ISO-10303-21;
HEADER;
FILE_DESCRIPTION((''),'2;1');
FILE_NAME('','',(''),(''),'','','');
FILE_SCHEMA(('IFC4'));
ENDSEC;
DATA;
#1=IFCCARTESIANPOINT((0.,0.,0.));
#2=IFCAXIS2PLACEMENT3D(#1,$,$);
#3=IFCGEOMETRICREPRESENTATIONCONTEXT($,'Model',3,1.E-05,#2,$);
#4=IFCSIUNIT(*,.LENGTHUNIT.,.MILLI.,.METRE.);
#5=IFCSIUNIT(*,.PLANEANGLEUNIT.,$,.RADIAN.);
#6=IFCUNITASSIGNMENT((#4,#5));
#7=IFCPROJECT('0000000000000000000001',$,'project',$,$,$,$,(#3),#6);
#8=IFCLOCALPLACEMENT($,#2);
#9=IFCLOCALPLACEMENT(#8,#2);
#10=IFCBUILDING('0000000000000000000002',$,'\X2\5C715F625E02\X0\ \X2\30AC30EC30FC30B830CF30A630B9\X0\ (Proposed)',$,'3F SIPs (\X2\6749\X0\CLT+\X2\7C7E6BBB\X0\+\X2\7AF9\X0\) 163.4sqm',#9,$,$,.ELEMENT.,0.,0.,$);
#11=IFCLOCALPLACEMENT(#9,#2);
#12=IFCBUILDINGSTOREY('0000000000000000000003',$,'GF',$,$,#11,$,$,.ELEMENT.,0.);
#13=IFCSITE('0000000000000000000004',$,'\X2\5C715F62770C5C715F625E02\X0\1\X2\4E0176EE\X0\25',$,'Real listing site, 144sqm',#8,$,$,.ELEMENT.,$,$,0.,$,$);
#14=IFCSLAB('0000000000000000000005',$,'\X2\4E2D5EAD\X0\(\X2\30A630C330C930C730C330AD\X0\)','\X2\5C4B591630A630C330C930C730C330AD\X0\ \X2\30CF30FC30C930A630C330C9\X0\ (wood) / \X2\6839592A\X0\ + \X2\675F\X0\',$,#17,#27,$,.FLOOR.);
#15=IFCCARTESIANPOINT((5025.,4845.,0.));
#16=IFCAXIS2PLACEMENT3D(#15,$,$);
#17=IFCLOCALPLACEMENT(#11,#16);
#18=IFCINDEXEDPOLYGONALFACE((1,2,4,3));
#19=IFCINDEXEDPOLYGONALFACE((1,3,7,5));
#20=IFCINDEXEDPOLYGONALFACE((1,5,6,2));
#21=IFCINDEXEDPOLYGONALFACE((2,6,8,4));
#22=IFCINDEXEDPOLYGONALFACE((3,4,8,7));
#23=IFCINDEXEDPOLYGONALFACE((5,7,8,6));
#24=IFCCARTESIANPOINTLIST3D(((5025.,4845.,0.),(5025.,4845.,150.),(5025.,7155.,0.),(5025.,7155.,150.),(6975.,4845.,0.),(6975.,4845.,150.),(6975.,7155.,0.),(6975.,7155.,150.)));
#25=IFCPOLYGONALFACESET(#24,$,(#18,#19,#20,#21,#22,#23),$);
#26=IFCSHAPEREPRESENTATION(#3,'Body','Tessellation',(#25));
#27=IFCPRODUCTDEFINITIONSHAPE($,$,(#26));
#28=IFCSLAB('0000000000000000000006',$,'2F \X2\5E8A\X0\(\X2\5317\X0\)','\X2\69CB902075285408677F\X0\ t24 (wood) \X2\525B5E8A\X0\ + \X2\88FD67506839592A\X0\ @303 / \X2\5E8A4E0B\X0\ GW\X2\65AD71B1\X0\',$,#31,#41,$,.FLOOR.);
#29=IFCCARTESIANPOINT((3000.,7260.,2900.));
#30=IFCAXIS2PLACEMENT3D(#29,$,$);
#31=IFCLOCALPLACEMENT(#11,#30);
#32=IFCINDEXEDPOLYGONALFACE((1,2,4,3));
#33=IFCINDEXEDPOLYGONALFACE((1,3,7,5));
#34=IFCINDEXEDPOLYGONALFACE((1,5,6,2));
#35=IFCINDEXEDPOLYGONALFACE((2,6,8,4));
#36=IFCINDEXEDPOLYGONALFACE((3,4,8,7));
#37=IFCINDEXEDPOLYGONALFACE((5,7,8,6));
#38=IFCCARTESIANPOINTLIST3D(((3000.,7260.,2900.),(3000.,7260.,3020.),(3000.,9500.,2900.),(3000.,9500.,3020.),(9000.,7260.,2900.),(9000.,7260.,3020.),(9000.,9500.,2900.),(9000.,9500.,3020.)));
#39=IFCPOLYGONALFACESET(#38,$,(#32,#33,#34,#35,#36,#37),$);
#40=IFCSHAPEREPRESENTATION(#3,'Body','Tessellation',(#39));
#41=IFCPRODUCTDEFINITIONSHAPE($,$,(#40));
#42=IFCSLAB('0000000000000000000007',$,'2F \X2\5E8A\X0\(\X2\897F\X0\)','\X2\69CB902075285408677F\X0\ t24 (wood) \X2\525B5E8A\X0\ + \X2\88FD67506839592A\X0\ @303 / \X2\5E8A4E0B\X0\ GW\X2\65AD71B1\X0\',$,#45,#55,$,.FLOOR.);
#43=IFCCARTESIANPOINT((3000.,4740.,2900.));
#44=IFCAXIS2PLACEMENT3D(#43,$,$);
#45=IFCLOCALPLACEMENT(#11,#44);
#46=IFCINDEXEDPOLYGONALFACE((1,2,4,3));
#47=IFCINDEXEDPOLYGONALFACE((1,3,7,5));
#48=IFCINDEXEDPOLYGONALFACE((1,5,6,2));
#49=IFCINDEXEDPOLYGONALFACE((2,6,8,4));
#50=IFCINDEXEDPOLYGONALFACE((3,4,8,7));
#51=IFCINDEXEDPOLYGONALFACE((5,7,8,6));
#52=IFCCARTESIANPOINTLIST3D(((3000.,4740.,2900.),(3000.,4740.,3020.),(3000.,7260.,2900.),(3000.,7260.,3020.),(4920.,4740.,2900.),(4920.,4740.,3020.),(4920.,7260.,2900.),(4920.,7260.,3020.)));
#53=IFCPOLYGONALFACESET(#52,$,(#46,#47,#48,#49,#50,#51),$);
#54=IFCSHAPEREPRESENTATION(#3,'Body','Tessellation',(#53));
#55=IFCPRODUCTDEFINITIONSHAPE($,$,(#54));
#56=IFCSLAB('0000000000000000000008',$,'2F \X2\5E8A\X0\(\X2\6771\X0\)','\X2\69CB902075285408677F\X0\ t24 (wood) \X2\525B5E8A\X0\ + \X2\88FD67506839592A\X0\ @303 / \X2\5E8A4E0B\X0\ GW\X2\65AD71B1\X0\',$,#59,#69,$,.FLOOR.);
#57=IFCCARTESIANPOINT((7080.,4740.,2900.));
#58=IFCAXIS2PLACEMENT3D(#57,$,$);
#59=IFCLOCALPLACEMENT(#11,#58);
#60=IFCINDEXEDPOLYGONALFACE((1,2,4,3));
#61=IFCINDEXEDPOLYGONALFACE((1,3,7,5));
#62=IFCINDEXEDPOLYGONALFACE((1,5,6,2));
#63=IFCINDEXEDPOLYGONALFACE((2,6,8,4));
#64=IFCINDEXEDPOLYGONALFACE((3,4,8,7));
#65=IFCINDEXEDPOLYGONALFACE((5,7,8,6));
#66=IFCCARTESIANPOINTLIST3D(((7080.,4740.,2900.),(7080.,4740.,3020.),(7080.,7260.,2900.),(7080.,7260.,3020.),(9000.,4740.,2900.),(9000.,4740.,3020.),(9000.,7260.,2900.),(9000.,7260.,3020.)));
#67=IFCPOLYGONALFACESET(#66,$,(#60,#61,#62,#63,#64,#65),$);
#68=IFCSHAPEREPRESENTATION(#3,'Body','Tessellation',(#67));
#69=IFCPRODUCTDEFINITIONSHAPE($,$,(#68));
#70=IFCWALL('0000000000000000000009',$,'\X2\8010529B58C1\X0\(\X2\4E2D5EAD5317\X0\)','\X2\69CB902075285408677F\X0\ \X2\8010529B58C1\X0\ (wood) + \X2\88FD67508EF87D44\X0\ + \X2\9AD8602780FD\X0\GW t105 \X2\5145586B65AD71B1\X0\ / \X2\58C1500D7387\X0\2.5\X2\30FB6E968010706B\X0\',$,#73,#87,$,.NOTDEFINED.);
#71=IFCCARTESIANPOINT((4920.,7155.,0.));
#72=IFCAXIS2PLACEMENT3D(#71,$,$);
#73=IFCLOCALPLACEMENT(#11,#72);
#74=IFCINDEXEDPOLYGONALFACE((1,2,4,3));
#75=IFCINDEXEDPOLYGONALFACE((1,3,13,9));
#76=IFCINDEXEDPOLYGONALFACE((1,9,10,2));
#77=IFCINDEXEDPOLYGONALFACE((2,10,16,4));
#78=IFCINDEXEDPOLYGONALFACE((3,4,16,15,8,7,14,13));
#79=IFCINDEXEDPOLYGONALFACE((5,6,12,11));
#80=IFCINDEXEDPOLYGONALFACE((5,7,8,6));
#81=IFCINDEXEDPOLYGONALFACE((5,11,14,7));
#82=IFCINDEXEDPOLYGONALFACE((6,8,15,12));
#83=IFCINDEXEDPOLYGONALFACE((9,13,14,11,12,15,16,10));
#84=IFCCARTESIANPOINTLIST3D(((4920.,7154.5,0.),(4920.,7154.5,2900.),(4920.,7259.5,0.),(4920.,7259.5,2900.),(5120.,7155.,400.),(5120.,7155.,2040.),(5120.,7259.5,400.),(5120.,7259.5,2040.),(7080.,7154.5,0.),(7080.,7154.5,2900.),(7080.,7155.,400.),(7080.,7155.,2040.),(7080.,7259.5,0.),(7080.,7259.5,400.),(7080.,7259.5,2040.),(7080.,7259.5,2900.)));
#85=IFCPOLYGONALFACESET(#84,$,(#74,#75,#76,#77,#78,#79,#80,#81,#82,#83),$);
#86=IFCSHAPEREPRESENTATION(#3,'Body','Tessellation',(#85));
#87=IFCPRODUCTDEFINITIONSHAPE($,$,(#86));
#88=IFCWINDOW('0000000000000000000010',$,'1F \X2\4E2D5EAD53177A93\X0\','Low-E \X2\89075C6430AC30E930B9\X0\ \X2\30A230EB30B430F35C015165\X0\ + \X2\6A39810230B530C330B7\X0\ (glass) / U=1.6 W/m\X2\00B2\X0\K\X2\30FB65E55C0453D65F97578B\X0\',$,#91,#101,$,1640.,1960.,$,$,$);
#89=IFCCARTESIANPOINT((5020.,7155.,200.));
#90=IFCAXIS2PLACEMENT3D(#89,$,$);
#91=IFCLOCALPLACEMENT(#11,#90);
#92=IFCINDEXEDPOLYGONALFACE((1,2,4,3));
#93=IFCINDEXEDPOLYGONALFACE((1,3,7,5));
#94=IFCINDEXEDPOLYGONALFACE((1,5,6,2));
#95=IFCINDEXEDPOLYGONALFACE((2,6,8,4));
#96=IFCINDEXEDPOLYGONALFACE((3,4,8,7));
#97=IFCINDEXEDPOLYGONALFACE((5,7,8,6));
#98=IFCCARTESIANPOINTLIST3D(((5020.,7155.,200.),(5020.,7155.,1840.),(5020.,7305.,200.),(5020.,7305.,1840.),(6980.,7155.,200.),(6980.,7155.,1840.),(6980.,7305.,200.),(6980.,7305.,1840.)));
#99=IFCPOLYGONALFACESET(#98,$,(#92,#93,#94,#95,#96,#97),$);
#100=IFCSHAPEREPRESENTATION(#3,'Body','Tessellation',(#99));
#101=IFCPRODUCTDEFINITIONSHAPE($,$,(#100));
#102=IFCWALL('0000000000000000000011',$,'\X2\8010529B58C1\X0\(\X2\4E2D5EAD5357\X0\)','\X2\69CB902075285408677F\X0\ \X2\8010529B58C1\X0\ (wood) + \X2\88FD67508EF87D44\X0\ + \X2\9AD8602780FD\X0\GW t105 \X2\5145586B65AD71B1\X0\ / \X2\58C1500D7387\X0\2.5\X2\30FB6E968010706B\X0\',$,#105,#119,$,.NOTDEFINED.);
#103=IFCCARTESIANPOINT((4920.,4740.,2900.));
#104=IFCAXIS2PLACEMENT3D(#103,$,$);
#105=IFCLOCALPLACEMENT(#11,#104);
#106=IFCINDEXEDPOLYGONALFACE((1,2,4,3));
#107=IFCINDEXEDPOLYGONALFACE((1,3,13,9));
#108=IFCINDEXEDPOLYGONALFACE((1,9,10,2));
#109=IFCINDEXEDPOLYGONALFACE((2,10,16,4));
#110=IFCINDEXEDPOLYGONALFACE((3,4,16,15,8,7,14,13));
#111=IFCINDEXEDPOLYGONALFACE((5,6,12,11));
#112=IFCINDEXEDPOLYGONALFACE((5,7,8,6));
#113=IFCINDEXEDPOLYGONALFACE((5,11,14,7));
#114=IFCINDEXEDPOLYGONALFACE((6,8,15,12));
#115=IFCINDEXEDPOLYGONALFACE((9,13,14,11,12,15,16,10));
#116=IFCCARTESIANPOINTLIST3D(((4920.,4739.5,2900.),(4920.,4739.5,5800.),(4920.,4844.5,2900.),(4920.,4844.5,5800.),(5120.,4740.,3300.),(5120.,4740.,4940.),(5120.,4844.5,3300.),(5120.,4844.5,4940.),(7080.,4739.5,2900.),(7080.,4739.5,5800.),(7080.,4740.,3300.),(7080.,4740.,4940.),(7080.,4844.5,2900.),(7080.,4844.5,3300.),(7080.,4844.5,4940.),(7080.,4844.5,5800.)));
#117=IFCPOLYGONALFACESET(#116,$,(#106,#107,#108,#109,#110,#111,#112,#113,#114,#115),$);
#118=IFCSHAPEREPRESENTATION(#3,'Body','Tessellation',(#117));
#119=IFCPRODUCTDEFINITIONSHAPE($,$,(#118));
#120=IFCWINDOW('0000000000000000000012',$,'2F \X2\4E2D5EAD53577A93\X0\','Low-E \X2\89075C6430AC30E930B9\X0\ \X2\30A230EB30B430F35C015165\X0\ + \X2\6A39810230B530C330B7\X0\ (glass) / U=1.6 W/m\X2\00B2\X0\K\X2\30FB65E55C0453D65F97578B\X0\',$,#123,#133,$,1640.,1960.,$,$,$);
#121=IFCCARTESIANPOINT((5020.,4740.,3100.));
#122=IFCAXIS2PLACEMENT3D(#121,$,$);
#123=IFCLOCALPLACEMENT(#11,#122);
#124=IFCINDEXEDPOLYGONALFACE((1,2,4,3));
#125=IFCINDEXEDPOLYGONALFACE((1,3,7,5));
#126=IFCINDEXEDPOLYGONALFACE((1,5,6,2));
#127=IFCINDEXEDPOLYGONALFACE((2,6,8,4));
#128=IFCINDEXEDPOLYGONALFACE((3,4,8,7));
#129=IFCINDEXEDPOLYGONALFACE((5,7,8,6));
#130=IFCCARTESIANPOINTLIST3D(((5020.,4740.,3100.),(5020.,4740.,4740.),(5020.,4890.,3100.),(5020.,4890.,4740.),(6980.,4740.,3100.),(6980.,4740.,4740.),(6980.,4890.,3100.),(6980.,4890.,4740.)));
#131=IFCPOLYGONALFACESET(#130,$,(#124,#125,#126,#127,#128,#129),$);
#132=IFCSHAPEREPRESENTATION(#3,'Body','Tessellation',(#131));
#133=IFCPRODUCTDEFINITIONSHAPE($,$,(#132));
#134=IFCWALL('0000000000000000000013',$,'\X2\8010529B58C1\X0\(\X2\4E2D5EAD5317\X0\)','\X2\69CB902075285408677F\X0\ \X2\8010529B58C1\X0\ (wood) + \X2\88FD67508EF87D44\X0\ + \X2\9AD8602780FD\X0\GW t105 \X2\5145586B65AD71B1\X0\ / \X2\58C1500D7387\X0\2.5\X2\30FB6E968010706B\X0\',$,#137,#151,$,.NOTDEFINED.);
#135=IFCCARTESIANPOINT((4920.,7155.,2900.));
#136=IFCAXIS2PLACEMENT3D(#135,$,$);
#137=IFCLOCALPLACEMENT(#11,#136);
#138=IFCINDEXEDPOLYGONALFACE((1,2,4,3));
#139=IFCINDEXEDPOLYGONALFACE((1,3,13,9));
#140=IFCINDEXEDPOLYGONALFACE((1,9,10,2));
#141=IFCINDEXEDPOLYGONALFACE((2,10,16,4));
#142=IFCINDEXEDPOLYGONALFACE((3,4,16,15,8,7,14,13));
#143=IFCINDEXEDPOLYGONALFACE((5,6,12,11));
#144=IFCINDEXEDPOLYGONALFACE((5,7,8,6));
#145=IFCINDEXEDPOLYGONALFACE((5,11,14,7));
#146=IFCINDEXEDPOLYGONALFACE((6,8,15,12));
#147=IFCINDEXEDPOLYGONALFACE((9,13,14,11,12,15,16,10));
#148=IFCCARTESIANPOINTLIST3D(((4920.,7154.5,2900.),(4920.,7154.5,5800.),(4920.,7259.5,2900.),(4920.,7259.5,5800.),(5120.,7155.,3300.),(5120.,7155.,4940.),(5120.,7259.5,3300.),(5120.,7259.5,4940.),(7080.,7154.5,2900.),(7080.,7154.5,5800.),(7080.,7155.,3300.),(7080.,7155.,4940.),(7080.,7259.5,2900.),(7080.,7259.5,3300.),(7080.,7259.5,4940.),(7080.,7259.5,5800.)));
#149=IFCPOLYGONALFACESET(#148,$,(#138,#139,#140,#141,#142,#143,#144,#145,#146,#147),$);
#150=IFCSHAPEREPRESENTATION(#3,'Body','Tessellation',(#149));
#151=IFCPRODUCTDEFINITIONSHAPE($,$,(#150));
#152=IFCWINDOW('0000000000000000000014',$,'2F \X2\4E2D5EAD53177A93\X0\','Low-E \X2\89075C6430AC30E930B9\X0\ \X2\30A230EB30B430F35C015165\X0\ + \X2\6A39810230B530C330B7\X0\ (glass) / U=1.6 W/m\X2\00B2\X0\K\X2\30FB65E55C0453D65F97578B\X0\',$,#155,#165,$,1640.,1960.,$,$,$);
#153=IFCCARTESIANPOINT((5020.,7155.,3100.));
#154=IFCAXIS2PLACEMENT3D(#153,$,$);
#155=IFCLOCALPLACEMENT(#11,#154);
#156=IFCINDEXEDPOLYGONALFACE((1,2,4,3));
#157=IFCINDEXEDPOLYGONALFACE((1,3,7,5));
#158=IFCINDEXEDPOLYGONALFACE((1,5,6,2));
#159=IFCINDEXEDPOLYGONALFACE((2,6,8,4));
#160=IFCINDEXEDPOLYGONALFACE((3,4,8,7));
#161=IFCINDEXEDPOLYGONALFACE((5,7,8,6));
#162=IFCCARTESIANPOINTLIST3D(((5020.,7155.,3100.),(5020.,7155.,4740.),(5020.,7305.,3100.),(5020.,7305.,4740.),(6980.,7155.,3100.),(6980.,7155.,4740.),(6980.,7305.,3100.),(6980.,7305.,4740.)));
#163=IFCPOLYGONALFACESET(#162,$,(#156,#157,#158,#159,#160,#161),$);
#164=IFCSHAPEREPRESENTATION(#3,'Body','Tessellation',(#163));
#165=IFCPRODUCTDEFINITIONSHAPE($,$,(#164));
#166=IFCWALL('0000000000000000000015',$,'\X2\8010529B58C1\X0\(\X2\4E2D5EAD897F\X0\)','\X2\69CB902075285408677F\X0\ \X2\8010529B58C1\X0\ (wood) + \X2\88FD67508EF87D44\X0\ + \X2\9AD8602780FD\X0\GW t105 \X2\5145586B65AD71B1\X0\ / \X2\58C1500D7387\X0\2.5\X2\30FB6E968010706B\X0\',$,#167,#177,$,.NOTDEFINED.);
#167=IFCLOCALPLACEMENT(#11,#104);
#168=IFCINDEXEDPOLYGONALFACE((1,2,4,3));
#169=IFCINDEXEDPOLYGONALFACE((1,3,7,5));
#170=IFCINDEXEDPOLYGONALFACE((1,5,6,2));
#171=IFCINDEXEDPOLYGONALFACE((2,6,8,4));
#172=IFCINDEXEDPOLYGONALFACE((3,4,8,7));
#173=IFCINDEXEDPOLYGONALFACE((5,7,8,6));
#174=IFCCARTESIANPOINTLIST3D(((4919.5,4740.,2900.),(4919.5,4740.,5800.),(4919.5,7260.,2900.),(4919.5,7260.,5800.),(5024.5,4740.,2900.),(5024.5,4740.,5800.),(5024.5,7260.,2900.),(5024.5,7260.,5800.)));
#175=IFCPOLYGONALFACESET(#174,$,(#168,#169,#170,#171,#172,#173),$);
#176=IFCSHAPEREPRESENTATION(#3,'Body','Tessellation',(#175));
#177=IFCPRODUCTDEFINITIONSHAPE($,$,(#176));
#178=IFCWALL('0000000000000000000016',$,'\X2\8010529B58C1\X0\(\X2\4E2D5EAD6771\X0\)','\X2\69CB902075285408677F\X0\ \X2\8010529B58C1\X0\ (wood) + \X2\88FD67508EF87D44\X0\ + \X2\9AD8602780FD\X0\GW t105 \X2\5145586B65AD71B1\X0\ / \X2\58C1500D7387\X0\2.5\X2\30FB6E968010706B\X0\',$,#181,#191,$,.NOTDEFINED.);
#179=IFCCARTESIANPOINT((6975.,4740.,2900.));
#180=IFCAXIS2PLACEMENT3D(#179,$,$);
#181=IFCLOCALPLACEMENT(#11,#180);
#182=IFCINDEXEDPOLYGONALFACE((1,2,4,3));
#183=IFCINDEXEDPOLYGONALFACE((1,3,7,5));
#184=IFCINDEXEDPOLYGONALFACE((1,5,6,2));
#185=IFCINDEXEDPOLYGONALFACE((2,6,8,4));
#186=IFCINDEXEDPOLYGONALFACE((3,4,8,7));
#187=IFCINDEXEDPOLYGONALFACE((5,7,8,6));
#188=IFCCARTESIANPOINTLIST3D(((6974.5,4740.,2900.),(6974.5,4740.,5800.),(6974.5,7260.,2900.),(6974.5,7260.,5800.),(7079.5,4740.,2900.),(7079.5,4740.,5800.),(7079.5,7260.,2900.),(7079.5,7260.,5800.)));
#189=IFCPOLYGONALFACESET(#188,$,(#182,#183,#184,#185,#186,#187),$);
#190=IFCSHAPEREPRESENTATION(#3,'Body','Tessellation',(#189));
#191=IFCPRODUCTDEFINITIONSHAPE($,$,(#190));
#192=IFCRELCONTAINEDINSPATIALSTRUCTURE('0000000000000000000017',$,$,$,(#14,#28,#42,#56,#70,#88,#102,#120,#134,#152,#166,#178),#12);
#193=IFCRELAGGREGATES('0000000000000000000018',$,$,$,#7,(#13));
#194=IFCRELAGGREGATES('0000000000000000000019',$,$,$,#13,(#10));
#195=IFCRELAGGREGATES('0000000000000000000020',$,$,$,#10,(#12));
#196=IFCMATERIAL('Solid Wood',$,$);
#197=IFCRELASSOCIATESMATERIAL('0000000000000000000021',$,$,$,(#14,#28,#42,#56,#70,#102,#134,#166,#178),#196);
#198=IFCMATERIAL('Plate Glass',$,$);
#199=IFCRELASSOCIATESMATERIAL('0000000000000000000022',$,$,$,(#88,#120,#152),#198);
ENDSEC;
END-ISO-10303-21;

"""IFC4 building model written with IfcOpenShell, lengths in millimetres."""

from ifc_helpers import new_model, si_unit, frame, frame_2d, origin, place, context, project, spatial, rectangle, extrude, material, element, fill, save


model = new_model("IFC4")

# Units and contexts
model_context = context("Model", 3, precision=1e-05, world=origin())
ifc_project = project(units=[si_unit("LENGTHUNIT", "METRE", prefix="MILLI"), si_unit("PLANEANGLEUNIT", "RADIAN")], contexts=[model_context])

# Site, building, storey
site_placement = place(None, origin())
site = spatial("IfcSite", under=ifc_project, at=site_placement, Name="山形県山形市1丁目25", ObjectType="Real listing site, 144sqm", CompositionType="ELEMENT", RefElevation=0.0)
building_placement = place(site_placement, origin())
building = spatial("IfcBuilding", under=site, at=building_placement, Name="山形市 ガレージハウス (Proposed)", ObjectType="3F SIPs (杉CLT+籾殻+竹) 163.4sqm", CompositionType="ELEMENT", ElevationOfRefHeight=0.0, ElevationOfTerrain=0.0)
storey_placement = place(building_placement, origin())
storey = spatial("IfcBuildingStorey", under=building, at=storey_placement, Name="GF", CompositionType="ELEMENT", Elevation=0.0)

# Slabs
ifc_material_1 = material(Name="Solid Wood")
slab_1_placement = place(storey_placement, frame((5025.0, 4845.0, 0.0)))
element("IfcSlab", 1, at=slab_1_placement, inside=storey, material=ifc_material_1, Name="中庭(ウッドデッキ)", Description="屋外ウッドデッキ ハードウッド (wood) / 根太 + 束", PredefinedType="FLOOR", context=model_context, shape_type="SweptSolid", body=[
    extrude(rectangle(XDim=1950.0, YDim=2310.0, at=frame_2d((975.0, 1155.0))), frame((5025.0, 4845.0, 0.0)), (0.0, 0.0, 1.0), 150.0),
])
slab_2_placement = place(storey_placement, frame((3000.0, 7260.0, 2900.0)))
element("IfcSlab", 2, at=slab_2_placement, inside=storey, material=ifc_material_1, Name="2F 床(北)", Description="構造用合板 t24 (wood) 剛床 + 製材根太 @303 / 床下 GW断熱", PredefinedType="FLOOR", context=model_context, shape_type="SweptSolid", body=[
    extrude(rectangle(XDim=6000.0, YDim=2240.0, at=frame_2d((3000.0, 1120.0))), frame((3000.0, 7260.0, 2900.0)), (0.0, 0.0, 1.0), 120.0),
])
slab_3_placement = place(storey_placement, frame((3000.0, 4740.0, 2900.0)))
element("IfcSlab", 3, at=slab_3_placement, inside=storey, material=ifc_material_1, Name="2F 床(西)", Description="構造用合板 t24 (wood) 剛床 + 製材根太 @303 / 床下 GW断熱", PredefinedType="FLOOR", context=model_context, shape_type="SweptSolid", body=[
    extrude(rectangle(XDim=1920.0, YDim=2520.0, at=frame_2d((960.0, 1260.0))), frame((3000.0, 4740.0, 2900.0)), (0.0, 0.0, 1.0), 120.0),
])
slab_4_placement = place(storey_placement, frame((7080.0, 4740.0, 2900.0)))
element("IfcSlab", 4, at=slab_4_placement, inside=storey, material=ifc_material_1, Name="2F 床(東)", Description="構造用合板 t24 (wood) 剛床 + 製材根太 @303 / 床下 GW断熱", PredefinedType="FLOOR", context=model_context, shape_type="SweptSolid", body=[
    extrude(rectangle(XDim=1920.0, YDim=2520.0, at=frame_2d((960.0, 1260.0))), frame((7080.0, 4740.0, 2900.0)), (0.0, 0.0, 1.0), 120.0),
])

# Wall, opening, window
wall_1_placement = place(storey_placement, frame((4920.0, 7155.0, 0.0)))
wall_1 = element("IfcWall", 5, at=wall_1_placement, inside=storey, material=ifc_material_1, Name="耐力壁(中庭北)", Description="構造用合板 耐力壁 (wood) + 製材軸組 + 高性能GW t105 充填断熱 / 壁倍率2.5・準耐火", PredefinedType="NOTDEFINED", context=model_context, shape_type="SweptSolid", body=[
    extrude(rectangle(XDim=2160.0, YDim=105.0, at=frame_2d((1080.0, 52.0))), frame((4920.0, 7155.0, 0.0)), (0.0, 0.0, 1.0), 2900.0),
])
opening_1_placement = place(storey_placement, frame((5020.0, 7155.0, 200.0)))
opening_1 = element("IfcOpeningElement", 6, at=opening_1_placement, cuts=wall_1, PredefinedType="NOTDEFINED", context=model_context, shape_type="SweptSolid", body=[
    extrude(rectangle(XDim=1960.0, YDim=150.0, at=frame_2d((980.0, 75.0))), frame((5020.0, 7155.0, 200.0)), (0.0, 0.0, 1.0), 1640.0),
])
ifc_material_2 = material(Name="Plate Glass")
window_1_placement = place(storey_placement, frame((5020.0, 7155.0, 200.0)))
window_1 = element("IfcWindow", 7, at=window_1_placement, inside=storey, material=ifc_material_2, Name="1F 中庭北窓", Description="Low-E 複層ガラス アルゴン封入 + 樹脂サッシ (glass) / U=1.6 W/m²K・日射取得型", OverallHeight=1640.0, OverallWidth=1960.0, context=model_context, shape_type="SweptSolid", body=[
    extrude(rectangle(XDim=1960.0, YDim=150.0, at=frame_2d((980.0, 75.0))), frame((5020.0, 7155.0, 200.0)), (0.0, 0.0, 1.0), 1640.0),
])
fill(opening_1, window_1)

# Walls, openings, windows
wall_2_placement = place(storey_placement, frame((4920.0, 4740.0, 2900.0)))
wall_2 = element("IfcWall", 8, at=wall_2_placement, inside=storey, material=ifc_material_1, Name="耐力壁(中庭南)", Description="構造用合板 耐力壁 (wood) + 製材軸組 + 高性能GW t105 充填断熱 / 壁倍率2.5・準耐火", PredefinedType="NOTDEFINED", context=model_context, shape_type="SweptSolid", body=[
    extrude(rectangle(XDim=2160.0, YDim=105.0, at=frame_2d((1080.0, 52.0))), frame((4920.0, 4740.0, 2900.0)), (0.0, 0.0, 1.0), 2900.0),
])
opening_2_placement = place(storey_placement, frame((5020.0, 4740.0, 3100.0)))
opening_2 = element("IfcOpeningElement", 9, at=opening_2_placement, cuts=wall_2, PredefinedType="NOTDEFINED", context=model_context, shape_type="SweptSolid", body=[
    extrude(rectangle(XDim=1960.0, YDim=150.0, at=frame_2d((980.0, 75.0))), frame((5020.0, 4740.0, 3100.0)), (0.0, 0.0, 1.0), 1640.0),
])
window_2_placement = place(storey_placement, frame((5020.0, 4740.0, 3100.0)))
window_2 = element("IfcWindow", 10, at=window_2_placement, inside=storey, material=ifc_material_2, Name="2F 中庭南窓", Description="Low-E 複層ガラス アルゴン封入 + 樹脂サッシ (glass) / U=1.6 W/m²K・日射取得型", OverallHeight=1640.0, OverallWidth=1960.0, context=model_context, shape_type="SweptSolid", body=[
    extrude(rectangle(XDim=1960.0, YDim=150.0, at=frame_2d((980.0, 75.0))), frame((5020.0, 4740.0, 3100.0)), (0.0, 0.0, 1.0), 1640.0),
])
fill(opening_2, window_2)
wall_3_placement = place(storey_placement, frame((4920.0, 7155.0, 2900.0)))
wall_3 = element("IfcWall", 11, at=wall_3_placement, inside=storey, material=ifc_material_1, Name="耐力壁(中庭北)", Description="構造用合板 耐力壁 (wood) + 製材軸組 + 高性能GW t105 充填断熱 / 壁倍率2.5・準耐火", PredefinedType="NOTDEFINED", context=model_context, shape_type="SweptSolid", body=[
    extrude(rectangle(XDim=2160.0, YDim=105.0, at=frame_2d((1080.0, 52.0))), frame((4920.0, 7155.0, 2900.0)), (0.0, 0.0, 1.0), 2900.0),
])
opening_3_placement = place(storey_placement, frame((5020.0, 7155.0, 3100.0)))
opening_3 = element("IfcOpeningElement", 12, at=opening_3_placement, cuts=wall_3, PredefinedType="NOTDEFINED", context=model_context, shape_type="SweptSolid", body=[
    extrude(rectangle(XDim=1960.0, YDim=150.0, at=frame_2d((980.0, 75.0))), frame((5020.0, 7155.0, 3100.0)), (0.0, 0.0, 1.0), 1640.0),
])
window_3_placement = place(storey_placement, frame((5020.0, 7155.0, 3100.0)))
window_3 = element("IfcWindow", 13, at=window_3_placement, inside=storey, material=ifc_material_2, Name="2F 中庭北窓", Description="Low-E 複層ガラス アルゴン封入 + 樹脂サッシ (glass) / U=1.6 W/m²K・日射取得型", OverallHeight=1640.0, OverallWidth=1960.0, context=model_context, shape_type="SweptSolid", body=[
    extrude(rectangle(XDim=1960.0, YDim=150.0, at=frame_2d((980.0, 75.0))), frame((5020.0, 7155.0, 3100.0)), (0.0, 0.0, 1.0), 1640.0),
])
fill(opening_3, window_3)

# Walls
wall_4_placement = place(storey_placement, frame((4920.0, 4740.0, 2900.0)))
element("IfcWall", 14, at=wall_4_placement, inside=storey, material=ifc_material_1, Name="耐力壁(中庭西)", Description="構造用合板 耐力壁 (wood) + 製材軸組 + 高性能GW t105 充填断熱 / 壁倍率2.5・準耐火", PredefinedType="NOTDEFINED", context=model_context, shape_type="SweptSolid", body=[
    extrude(rectangle(XDim=105.0, YDim=2520.0, at=frame_2d((52.0, 1260.0))), frame((4920.0, 4740.0, 2900.0)), (0.0, 0.0, 1.0), 2900.0),
])
wall_5_placement = place(storey_placement, frame((6975.0, 4740.0, 2900.0)))
element("IfcWall", 15, at=wall_5_placement, inside=storey, material=ifc_material_1, Name="耐力壁(中庭東)", Description="構造用合板 耐力壁 (wood) + 製材軸組 + 高性能GW t105 充填断熱 / 壁倍率2.5・準耐火", PredefinedType="NOTDEFINED", context=model_context, shape_type="SweptSolid", body=[
    extrude(rectangle(XDim=105.0, YDim=2520.0, at=frame_2d((52.0, 1260.0))), frame((6975.0, 4740.0, 2900.0)), (0.0, 0.0, 1.0), 2900.0),
])

save(model, "model.ifc")
